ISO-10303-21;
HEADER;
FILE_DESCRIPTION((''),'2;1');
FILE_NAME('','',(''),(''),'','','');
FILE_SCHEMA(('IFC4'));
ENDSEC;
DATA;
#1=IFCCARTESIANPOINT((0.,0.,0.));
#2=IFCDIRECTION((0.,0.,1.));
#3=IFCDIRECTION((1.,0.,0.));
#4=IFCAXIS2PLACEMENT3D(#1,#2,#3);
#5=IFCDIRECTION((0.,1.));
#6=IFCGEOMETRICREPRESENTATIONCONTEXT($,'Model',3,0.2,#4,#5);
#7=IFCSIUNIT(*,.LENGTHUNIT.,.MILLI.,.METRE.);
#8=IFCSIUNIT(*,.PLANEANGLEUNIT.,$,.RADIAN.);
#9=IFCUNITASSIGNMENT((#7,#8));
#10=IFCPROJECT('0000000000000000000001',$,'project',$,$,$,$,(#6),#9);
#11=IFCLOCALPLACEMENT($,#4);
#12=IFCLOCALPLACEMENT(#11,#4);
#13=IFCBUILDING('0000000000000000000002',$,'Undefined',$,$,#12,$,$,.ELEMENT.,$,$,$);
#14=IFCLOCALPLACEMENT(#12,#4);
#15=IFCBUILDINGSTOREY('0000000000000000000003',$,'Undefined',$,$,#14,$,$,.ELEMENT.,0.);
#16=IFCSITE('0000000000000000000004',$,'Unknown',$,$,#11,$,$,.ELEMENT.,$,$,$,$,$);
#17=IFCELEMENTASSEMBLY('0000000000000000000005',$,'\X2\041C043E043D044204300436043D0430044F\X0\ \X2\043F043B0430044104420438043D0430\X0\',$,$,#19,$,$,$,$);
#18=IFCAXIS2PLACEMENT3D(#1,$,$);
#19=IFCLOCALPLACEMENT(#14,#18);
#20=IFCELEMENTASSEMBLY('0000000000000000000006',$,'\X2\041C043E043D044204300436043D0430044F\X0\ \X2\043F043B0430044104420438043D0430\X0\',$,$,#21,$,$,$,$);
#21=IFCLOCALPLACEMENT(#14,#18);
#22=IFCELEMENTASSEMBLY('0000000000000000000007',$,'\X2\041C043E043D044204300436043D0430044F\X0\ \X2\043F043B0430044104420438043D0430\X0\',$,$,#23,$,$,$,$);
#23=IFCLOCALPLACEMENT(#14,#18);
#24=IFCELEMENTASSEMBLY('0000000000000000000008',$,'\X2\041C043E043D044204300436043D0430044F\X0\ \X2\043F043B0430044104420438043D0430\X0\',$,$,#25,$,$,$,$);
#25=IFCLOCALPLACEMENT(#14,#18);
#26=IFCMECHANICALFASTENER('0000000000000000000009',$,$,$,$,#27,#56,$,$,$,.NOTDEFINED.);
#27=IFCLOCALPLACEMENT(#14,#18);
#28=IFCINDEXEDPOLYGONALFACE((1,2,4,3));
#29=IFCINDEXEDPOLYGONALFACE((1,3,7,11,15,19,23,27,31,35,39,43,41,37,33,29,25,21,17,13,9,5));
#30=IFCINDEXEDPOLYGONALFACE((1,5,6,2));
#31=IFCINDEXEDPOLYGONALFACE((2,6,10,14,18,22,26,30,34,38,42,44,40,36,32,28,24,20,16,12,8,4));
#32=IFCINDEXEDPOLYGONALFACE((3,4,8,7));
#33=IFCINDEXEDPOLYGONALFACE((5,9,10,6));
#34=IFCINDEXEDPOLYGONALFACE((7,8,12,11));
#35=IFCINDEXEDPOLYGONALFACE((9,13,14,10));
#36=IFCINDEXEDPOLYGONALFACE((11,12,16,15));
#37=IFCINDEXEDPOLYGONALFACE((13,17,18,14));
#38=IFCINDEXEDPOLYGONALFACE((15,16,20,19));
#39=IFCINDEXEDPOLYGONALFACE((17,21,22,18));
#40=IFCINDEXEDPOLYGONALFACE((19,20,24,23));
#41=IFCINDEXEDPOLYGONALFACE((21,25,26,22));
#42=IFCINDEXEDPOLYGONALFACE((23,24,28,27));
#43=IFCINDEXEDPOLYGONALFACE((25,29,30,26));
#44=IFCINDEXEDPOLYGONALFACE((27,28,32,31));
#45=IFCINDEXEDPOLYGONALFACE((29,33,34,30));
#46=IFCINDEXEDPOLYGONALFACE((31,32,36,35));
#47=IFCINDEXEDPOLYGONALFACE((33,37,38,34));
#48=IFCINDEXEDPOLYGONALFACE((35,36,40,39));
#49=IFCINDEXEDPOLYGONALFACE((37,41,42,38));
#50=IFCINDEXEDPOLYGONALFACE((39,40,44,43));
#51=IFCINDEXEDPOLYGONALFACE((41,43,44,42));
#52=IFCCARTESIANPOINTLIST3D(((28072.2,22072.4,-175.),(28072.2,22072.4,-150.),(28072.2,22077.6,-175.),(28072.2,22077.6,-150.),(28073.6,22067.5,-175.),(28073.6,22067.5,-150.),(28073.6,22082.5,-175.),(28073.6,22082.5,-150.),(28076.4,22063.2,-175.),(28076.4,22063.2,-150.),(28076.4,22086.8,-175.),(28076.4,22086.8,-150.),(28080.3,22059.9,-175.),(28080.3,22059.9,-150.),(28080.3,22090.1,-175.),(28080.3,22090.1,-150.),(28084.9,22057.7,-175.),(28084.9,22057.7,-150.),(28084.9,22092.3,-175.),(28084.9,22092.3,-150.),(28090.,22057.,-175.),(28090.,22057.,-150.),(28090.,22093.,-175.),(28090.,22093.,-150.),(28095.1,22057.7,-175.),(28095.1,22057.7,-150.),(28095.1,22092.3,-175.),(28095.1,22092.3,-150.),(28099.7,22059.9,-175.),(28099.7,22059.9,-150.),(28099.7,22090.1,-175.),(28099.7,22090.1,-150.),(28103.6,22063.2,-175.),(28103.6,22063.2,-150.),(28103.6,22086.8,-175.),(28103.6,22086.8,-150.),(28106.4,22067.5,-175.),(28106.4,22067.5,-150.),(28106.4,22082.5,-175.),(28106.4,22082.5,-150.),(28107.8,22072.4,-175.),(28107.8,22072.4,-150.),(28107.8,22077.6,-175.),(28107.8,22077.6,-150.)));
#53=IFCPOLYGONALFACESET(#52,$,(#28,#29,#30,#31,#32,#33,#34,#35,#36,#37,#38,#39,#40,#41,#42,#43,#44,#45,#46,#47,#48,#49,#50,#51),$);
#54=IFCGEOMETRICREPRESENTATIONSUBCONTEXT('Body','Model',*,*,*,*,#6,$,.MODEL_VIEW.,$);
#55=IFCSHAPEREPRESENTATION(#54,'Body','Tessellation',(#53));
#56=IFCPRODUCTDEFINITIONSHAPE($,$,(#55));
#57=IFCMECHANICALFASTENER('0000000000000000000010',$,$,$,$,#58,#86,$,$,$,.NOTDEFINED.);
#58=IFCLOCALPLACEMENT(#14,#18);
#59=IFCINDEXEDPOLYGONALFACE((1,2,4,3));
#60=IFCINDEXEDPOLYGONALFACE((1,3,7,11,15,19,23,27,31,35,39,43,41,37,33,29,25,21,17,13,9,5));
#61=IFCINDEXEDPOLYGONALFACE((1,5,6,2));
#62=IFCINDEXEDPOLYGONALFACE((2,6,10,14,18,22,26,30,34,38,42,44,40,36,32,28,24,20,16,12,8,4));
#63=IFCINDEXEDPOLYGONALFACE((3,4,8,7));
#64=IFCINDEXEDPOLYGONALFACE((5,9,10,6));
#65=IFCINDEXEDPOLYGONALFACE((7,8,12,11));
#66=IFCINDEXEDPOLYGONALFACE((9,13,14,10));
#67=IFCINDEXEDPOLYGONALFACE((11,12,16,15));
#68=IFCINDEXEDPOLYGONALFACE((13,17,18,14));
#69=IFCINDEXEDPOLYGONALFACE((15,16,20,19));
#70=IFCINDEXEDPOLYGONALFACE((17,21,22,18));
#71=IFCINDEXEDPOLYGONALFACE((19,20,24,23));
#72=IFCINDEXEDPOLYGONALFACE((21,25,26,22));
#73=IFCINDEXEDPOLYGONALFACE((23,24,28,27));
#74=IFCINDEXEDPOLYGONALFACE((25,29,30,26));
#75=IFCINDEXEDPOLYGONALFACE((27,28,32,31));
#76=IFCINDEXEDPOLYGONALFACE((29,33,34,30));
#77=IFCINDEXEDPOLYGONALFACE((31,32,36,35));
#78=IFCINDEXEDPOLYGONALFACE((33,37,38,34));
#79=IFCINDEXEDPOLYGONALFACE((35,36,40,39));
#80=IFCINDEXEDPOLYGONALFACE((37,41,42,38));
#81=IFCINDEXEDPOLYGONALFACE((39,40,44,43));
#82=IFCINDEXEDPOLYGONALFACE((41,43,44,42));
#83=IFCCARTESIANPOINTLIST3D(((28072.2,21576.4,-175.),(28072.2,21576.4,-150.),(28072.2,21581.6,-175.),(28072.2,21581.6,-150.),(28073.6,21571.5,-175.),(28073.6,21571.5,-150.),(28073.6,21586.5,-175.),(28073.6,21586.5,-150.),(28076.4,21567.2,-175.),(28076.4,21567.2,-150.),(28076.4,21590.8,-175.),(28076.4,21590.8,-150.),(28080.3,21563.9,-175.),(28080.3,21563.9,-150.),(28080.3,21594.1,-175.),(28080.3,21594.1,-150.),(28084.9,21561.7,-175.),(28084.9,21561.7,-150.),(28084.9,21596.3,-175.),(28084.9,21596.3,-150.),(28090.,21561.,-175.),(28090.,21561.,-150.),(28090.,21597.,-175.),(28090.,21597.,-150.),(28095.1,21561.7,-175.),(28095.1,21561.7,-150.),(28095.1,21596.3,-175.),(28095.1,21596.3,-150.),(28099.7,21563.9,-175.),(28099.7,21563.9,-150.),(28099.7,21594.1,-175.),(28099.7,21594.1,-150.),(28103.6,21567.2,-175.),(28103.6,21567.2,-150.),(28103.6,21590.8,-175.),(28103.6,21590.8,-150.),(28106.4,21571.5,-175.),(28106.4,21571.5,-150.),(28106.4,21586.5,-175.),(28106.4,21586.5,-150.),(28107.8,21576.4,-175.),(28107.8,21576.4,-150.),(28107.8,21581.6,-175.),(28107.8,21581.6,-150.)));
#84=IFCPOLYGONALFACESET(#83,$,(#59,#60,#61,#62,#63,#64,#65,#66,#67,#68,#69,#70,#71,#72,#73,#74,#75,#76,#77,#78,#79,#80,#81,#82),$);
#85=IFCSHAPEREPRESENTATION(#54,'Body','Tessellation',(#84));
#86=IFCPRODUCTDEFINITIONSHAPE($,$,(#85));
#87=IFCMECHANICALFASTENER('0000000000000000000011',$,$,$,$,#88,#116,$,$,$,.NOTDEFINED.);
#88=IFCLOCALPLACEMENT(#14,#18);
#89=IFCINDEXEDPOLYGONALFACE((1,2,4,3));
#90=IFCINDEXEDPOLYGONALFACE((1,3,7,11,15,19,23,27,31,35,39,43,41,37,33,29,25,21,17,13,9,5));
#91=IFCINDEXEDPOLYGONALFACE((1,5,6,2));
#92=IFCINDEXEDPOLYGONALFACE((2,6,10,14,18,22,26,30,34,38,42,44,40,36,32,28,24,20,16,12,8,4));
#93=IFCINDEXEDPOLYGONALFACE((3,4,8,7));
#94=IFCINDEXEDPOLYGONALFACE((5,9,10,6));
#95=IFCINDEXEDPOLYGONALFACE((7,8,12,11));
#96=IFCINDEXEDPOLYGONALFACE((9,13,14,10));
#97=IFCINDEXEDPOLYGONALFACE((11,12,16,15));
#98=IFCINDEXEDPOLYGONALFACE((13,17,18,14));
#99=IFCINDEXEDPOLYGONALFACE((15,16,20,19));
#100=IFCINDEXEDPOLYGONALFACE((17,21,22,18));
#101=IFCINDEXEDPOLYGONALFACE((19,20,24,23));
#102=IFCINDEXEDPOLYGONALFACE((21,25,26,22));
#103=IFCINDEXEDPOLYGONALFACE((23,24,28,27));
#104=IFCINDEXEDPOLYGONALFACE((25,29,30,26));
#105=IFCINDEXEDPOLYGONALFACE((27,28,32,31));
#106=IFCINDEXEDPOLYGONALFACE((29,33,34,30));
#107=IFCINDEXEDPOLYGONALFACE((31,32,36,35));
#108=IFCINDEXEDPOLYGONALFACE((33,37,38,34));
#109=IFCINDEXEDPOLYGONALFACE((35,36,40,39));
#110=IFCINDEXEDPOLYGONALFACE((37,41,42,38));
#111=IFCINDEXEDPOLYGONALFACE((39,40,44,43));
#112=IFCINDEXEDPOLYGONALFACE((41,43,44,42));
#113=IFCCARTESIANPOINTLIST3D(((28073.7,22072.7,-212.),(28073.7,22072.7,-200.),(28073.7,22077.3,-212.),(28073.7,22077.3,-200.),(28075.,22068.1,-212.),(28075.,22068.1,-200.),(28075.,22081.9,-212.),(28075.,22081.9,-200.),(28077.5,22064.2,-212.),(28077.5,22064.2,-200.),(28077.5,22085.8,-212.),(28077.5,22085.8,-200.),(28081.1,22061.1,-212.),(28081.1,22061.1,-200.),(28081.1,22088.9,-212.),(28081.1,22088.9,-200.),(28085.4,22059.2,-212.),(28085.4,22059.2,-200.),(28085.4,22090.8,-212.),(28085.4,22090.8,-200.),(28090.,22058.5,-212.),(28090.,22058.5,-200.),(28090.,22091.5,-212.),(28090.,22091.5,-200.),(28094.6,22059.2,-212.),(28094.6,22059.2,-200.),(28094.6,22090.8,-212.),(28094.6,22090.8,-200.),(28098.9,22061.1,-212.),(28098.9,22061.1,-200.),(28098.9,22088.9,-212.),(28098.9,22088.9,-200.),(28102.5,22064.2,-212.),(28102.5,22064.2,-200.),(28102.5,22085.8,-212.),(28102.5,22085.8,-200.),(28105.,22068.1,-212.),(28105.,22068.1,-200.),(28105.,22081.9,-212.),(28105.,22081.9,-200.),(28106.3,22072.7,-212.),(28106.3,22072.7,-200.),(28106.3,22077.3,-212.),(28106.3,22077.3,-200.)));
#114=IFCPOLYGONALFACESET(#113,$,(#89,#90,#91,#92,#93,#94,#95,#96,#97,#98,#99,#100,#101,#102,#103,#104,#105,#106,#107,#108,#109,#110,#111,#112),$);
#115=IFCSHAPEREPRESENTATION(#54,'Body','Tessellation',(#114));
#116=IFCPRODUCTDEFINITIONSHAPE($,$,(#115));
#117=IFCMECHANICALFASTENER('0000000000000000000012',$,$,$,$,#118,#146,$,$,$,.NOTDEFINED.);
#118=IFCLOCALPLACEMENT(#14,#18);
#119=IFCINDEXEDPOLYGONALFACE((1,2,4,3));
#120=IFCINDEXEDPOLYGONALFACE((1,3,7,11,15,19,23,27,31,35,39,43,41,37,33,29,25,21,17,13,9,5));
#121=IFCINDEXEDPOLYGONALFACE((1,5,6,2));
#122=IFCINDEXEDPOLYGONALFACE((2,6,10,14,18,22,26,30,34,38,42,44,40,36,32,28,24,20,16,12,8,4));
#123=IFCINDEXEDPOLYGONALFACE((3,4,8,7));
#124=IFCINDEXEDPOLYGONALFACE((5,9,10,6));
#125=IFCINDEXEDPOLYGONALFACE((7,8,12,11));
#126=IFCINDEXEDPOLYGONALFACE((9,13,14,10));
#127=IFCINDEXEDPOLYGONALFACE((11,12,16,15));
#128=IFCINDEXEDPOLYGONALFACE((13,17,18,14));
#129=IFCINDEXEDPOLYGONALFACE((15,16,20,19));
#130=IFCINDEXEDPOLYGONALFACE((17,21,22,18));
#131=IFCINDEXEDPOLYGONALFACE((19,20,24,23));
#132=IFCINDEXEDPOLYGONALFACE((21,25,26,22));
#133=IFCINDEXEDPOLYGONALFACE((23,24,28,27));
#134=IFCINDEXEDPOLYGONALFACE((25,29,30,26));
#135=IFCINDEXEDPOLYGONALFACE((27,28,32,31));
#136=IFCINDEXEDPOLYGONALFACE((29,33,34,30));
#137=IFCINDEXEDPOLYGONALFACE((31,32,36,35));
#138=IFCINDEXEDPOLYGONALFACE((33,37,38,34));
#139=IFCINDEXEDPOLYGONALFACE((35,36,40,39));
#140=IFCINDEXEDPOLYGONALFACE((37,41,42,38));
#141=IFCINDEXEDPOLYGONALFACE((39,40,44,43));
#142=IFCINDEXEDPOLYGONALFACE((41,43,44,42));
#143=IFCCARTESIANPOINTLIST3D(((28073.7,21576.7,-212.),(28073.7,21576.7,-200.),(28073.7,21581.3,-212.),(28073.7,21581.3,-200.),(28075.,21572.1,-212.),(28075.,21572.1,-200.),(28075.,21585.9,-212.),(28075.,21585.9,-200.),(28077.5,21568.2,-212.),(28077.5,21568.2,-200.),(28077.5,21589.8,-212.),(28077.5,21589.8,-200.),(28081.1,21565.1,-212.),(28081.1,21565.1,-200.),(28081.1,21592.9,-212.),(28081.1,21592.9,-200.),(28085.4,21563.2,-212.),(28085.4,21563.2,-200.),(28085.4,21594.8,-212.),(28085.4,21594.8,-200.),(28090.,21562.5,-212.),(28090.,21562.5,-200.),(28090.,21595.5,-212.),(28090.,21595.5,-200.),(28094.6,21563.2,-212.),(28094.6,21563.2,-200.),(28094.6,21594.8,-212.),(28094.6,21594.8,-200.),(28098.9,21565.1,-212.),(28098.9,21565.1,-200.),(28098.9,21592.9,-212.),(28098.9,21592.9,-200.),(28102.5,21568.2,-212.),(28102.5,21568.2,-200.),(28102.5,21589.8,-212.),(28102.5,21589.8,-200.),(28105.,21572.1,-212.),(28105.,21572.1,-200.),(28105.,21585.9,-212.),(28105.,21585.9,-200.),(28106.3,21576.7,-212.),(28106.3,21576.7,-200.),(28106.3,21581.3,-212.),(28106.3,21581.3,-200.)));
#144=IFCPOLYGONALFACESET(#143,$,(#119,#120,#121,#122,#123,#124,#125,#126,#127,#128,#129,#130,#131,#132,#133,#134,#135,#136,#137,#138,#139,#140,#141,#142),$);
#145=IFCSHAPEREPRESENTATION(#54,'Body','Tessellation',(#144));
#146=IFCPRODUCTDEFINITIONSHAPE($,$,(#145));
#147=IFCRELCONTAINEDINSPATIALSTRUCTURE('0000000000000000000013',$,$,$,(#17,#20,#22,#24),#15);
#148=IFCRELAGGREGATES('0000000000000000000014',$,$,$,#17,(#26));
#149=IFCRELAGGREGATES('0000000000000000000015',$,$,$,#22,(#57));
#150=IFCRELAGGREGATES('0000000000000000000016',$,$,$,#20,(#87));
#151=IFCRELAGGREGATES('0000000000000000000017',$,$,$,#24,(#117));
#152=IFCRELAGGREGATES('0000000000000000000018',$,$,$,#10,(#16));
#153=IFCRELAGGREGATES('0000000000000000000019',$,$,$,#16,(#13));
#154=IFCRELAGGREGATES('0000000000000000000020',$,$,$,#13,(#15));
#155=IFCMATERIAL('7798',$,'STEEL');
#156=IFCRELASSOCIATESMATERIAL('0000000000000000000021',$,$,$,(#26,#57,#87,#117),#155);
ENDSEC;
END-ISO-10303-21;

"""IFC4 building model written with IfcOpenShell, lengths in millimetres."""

from ifc_helpers import new_model, si_unit, direction, frame, origin_with_axes, place, context, subcontext, project, spatial, arc, indexed_curve, outline, extrude, source, transform, mapped, material, element, aggregate, save


model = new_model("IFC4")

# Units and contexts
model_context = context("Model", 3, precision=0.2, world=origin_with_axes(), true_north=direction((0.0, 1.0)))
body_context = subcontext(model_context, "Body", "Model", "MODEL_VIEW")
ifc_project = project(units=[si_unit("LENGTHUNIT", "METRE", prefix="MILLI"), si_unit("PLANEANGLEUNIT", "RADIAN")], contexts=[model_context])

# Site, building, storey
site_placement = place(None, origin_with_axes())
site = spatial("IfcSite", under=ifc_project, at=site_placement, Name="Unknown", CompositionType="ELEMENT")
building_placement = place(site_placement, origin_with_axes())
building = spatial("IfcBuilding", under=site, at=building_placement, Name="Undefined", CompositionType="ELEMENT")
storey_placement = place(building_placement, origin_with_axes())
storey = spatial("IfcBuildingStorey", under=building, at=storey_placement, Name="Undefined", CompositionType="ELEMENT", Elevation=0.0)

# Element assemblies
assembly_1_placement = place(storey_placement, frame((28140.0, 22075.0, -162.5), z_axis=(0.0, 0.0, -1.0), x_axis=(-1.0, 0.0, 0.0)))
assembly_1 = element("IfcElementAssembly", 1, at=assembly_1_placement, inside=storey, Name="Монтажная пластина")
assembly_2_placement = place(storey_placement, frame((28140.0, 22075.0, -206.0), z_axis=(0.0, 0.0, -1.0), x_axis=(-1.0, 0.0, 0.0)))
assembly_2 = element("IfcElementAssembly", 2, at=assembly_2_placement, inside=storey, Name="Монтажная пластина")
assembly_3_placement = place(storey_placement, frame((28140.0, 21579.0, -162.5), z_axis=(0.0, 0.0, -1.0), x_axis=(-1.0, 0.0, 0.0)))
assembly_3 = element("IfcElementAssembly", 3, at=assembly_3_placement, inside=storey, Name="Монтажная пластина")
assembly_4_placement = place(storey_placement, frame((28140.0, 21579.0, -206.0), z_axis=(0.0, 0.0, -1.0), x_axis=(-1.0, 0.0, 0.0)))
assembly_4 = element("IfcElementAssembly", 4, at=assembly_4_placement, inside=storey, Name="Монтажная пластина")

# Shared definitions
ifc_material_1 = material(Name="7798", Category="STEEL")

# Mechanical fasteners
shared_shape_1 = source(origin_with_axes(), body_context, "Body", "SweptSolid", [
    extrude(outline(indexed_curve([(18.0, 0.0), (0.0, 18.0), (-18.0, 0.0), (0.0, -18.0)], segments=[arc(1, 2, 3), arc(3, 4, 1)])), frame((0.0, 0.0, 0.0), z_axis=(0.0, 0.0, -1.0), x_axis=(0.0, 1.0, 0.0)), (0.0, 0.0, 1.0), 25.0),
])
mechanical_fastener_1_placement = place(assembly_1_placement, frame((50.0, 0.0, 12.5), z_axis=(0.0, 0.0, 1.0), x_axis=(1.0, 0.0, 0.0)))
mechanical_fastener_1 = element("IfcMechanicalFastener", 5, at=mechanical_fastener_1_placement, material=ifc_material_1, PredefinedType="NOTDEFINED", context=body_context, shape_type="MappedRepresentation", body=[
    mapped(shared_shape_1, transform((0.0, 0.0, 0.0))),
])
aggregate(assembly_1, [mechanical_fastener_1])
mechanical_fastener_2_placement = place(assembly_3_placement, frame((50.0, 0.0, 12.5), z_axis=(0.0, 0.0, 1.0), x_axis=(1.0, 0.0, 0.0)))
mechanical_fastener_2 = element("IfcMechanicalFastener", 6, at=mechanical_fastener_2_placement, material=ifc_material_1, PredefinedType="NOTDEFINED", context=body_context, shape_type="MappedRepresentation", body=[
    mapped(shared_shape_1, transform((0.0, 0.0, 0.0))),
])
aggregate(assembly_3, [mechanical_fastener_2])
shared_shape_2 = source(origin_with_axes(), body_context, "Body", "SweptSolid", [
    extrude(outline(indexed_curve([(16.5, 0.0), (0.0, 16.5), (-16.5, 0.0), (0.0, -16.5)], segments=[arc(1, 2, 3), arc(3, 4, 1)])), frame((0.0, 0.0, 12.0), z_axis=(0.0, 0.0, -1.0), x_axis=(0.0, 1.0, 0.0)), (0.0, 0.0, 1.0), 12.0),
])
mechanical_fastener_3_placement = place(assembly_2_placement, frame((50.0, 0.0, -6.0), z_axis=(0.0, 0.0, 1.0), x_axis=(1.0, 0.0, 0.0)))
mechanical_fastener_3 = element("IfcMechanicalFastener", 7, at=mechanical_fastener_3_placement, material=ifc_material_1, PredefinedType="NOTDEFINED", context=body_context, shape_type="MappedRepresentation", body=[
    mapped(shared_shape_2, transform((0.0, 0.0, 0.0))),
])
aggregate(assembly_2, [mechanical_fastener_3])
mechanical_fastener_4_placement = place(assembly_4_placement, frame((50.0, 0.0, -6.0), z_axis=(0.0, 0.0, 1.0), x_axis=(1.0, 0.0, 0.0)))
mechanical_fastener_4 = element("IfcMechanicalFastener", 8, at=mechanical_fastener_4_placement, material=ifc_material_1, PredefinedType="NOTDEFINED", context=body_context, shape_type="MappedRepresentation", body=[
    mapped(shared_shape_2, transform((0.0, 0.0, 0.0))),
])
aggregate(assembly_4, [mechanical_fastener_4])

save(model, "model.ifc")
